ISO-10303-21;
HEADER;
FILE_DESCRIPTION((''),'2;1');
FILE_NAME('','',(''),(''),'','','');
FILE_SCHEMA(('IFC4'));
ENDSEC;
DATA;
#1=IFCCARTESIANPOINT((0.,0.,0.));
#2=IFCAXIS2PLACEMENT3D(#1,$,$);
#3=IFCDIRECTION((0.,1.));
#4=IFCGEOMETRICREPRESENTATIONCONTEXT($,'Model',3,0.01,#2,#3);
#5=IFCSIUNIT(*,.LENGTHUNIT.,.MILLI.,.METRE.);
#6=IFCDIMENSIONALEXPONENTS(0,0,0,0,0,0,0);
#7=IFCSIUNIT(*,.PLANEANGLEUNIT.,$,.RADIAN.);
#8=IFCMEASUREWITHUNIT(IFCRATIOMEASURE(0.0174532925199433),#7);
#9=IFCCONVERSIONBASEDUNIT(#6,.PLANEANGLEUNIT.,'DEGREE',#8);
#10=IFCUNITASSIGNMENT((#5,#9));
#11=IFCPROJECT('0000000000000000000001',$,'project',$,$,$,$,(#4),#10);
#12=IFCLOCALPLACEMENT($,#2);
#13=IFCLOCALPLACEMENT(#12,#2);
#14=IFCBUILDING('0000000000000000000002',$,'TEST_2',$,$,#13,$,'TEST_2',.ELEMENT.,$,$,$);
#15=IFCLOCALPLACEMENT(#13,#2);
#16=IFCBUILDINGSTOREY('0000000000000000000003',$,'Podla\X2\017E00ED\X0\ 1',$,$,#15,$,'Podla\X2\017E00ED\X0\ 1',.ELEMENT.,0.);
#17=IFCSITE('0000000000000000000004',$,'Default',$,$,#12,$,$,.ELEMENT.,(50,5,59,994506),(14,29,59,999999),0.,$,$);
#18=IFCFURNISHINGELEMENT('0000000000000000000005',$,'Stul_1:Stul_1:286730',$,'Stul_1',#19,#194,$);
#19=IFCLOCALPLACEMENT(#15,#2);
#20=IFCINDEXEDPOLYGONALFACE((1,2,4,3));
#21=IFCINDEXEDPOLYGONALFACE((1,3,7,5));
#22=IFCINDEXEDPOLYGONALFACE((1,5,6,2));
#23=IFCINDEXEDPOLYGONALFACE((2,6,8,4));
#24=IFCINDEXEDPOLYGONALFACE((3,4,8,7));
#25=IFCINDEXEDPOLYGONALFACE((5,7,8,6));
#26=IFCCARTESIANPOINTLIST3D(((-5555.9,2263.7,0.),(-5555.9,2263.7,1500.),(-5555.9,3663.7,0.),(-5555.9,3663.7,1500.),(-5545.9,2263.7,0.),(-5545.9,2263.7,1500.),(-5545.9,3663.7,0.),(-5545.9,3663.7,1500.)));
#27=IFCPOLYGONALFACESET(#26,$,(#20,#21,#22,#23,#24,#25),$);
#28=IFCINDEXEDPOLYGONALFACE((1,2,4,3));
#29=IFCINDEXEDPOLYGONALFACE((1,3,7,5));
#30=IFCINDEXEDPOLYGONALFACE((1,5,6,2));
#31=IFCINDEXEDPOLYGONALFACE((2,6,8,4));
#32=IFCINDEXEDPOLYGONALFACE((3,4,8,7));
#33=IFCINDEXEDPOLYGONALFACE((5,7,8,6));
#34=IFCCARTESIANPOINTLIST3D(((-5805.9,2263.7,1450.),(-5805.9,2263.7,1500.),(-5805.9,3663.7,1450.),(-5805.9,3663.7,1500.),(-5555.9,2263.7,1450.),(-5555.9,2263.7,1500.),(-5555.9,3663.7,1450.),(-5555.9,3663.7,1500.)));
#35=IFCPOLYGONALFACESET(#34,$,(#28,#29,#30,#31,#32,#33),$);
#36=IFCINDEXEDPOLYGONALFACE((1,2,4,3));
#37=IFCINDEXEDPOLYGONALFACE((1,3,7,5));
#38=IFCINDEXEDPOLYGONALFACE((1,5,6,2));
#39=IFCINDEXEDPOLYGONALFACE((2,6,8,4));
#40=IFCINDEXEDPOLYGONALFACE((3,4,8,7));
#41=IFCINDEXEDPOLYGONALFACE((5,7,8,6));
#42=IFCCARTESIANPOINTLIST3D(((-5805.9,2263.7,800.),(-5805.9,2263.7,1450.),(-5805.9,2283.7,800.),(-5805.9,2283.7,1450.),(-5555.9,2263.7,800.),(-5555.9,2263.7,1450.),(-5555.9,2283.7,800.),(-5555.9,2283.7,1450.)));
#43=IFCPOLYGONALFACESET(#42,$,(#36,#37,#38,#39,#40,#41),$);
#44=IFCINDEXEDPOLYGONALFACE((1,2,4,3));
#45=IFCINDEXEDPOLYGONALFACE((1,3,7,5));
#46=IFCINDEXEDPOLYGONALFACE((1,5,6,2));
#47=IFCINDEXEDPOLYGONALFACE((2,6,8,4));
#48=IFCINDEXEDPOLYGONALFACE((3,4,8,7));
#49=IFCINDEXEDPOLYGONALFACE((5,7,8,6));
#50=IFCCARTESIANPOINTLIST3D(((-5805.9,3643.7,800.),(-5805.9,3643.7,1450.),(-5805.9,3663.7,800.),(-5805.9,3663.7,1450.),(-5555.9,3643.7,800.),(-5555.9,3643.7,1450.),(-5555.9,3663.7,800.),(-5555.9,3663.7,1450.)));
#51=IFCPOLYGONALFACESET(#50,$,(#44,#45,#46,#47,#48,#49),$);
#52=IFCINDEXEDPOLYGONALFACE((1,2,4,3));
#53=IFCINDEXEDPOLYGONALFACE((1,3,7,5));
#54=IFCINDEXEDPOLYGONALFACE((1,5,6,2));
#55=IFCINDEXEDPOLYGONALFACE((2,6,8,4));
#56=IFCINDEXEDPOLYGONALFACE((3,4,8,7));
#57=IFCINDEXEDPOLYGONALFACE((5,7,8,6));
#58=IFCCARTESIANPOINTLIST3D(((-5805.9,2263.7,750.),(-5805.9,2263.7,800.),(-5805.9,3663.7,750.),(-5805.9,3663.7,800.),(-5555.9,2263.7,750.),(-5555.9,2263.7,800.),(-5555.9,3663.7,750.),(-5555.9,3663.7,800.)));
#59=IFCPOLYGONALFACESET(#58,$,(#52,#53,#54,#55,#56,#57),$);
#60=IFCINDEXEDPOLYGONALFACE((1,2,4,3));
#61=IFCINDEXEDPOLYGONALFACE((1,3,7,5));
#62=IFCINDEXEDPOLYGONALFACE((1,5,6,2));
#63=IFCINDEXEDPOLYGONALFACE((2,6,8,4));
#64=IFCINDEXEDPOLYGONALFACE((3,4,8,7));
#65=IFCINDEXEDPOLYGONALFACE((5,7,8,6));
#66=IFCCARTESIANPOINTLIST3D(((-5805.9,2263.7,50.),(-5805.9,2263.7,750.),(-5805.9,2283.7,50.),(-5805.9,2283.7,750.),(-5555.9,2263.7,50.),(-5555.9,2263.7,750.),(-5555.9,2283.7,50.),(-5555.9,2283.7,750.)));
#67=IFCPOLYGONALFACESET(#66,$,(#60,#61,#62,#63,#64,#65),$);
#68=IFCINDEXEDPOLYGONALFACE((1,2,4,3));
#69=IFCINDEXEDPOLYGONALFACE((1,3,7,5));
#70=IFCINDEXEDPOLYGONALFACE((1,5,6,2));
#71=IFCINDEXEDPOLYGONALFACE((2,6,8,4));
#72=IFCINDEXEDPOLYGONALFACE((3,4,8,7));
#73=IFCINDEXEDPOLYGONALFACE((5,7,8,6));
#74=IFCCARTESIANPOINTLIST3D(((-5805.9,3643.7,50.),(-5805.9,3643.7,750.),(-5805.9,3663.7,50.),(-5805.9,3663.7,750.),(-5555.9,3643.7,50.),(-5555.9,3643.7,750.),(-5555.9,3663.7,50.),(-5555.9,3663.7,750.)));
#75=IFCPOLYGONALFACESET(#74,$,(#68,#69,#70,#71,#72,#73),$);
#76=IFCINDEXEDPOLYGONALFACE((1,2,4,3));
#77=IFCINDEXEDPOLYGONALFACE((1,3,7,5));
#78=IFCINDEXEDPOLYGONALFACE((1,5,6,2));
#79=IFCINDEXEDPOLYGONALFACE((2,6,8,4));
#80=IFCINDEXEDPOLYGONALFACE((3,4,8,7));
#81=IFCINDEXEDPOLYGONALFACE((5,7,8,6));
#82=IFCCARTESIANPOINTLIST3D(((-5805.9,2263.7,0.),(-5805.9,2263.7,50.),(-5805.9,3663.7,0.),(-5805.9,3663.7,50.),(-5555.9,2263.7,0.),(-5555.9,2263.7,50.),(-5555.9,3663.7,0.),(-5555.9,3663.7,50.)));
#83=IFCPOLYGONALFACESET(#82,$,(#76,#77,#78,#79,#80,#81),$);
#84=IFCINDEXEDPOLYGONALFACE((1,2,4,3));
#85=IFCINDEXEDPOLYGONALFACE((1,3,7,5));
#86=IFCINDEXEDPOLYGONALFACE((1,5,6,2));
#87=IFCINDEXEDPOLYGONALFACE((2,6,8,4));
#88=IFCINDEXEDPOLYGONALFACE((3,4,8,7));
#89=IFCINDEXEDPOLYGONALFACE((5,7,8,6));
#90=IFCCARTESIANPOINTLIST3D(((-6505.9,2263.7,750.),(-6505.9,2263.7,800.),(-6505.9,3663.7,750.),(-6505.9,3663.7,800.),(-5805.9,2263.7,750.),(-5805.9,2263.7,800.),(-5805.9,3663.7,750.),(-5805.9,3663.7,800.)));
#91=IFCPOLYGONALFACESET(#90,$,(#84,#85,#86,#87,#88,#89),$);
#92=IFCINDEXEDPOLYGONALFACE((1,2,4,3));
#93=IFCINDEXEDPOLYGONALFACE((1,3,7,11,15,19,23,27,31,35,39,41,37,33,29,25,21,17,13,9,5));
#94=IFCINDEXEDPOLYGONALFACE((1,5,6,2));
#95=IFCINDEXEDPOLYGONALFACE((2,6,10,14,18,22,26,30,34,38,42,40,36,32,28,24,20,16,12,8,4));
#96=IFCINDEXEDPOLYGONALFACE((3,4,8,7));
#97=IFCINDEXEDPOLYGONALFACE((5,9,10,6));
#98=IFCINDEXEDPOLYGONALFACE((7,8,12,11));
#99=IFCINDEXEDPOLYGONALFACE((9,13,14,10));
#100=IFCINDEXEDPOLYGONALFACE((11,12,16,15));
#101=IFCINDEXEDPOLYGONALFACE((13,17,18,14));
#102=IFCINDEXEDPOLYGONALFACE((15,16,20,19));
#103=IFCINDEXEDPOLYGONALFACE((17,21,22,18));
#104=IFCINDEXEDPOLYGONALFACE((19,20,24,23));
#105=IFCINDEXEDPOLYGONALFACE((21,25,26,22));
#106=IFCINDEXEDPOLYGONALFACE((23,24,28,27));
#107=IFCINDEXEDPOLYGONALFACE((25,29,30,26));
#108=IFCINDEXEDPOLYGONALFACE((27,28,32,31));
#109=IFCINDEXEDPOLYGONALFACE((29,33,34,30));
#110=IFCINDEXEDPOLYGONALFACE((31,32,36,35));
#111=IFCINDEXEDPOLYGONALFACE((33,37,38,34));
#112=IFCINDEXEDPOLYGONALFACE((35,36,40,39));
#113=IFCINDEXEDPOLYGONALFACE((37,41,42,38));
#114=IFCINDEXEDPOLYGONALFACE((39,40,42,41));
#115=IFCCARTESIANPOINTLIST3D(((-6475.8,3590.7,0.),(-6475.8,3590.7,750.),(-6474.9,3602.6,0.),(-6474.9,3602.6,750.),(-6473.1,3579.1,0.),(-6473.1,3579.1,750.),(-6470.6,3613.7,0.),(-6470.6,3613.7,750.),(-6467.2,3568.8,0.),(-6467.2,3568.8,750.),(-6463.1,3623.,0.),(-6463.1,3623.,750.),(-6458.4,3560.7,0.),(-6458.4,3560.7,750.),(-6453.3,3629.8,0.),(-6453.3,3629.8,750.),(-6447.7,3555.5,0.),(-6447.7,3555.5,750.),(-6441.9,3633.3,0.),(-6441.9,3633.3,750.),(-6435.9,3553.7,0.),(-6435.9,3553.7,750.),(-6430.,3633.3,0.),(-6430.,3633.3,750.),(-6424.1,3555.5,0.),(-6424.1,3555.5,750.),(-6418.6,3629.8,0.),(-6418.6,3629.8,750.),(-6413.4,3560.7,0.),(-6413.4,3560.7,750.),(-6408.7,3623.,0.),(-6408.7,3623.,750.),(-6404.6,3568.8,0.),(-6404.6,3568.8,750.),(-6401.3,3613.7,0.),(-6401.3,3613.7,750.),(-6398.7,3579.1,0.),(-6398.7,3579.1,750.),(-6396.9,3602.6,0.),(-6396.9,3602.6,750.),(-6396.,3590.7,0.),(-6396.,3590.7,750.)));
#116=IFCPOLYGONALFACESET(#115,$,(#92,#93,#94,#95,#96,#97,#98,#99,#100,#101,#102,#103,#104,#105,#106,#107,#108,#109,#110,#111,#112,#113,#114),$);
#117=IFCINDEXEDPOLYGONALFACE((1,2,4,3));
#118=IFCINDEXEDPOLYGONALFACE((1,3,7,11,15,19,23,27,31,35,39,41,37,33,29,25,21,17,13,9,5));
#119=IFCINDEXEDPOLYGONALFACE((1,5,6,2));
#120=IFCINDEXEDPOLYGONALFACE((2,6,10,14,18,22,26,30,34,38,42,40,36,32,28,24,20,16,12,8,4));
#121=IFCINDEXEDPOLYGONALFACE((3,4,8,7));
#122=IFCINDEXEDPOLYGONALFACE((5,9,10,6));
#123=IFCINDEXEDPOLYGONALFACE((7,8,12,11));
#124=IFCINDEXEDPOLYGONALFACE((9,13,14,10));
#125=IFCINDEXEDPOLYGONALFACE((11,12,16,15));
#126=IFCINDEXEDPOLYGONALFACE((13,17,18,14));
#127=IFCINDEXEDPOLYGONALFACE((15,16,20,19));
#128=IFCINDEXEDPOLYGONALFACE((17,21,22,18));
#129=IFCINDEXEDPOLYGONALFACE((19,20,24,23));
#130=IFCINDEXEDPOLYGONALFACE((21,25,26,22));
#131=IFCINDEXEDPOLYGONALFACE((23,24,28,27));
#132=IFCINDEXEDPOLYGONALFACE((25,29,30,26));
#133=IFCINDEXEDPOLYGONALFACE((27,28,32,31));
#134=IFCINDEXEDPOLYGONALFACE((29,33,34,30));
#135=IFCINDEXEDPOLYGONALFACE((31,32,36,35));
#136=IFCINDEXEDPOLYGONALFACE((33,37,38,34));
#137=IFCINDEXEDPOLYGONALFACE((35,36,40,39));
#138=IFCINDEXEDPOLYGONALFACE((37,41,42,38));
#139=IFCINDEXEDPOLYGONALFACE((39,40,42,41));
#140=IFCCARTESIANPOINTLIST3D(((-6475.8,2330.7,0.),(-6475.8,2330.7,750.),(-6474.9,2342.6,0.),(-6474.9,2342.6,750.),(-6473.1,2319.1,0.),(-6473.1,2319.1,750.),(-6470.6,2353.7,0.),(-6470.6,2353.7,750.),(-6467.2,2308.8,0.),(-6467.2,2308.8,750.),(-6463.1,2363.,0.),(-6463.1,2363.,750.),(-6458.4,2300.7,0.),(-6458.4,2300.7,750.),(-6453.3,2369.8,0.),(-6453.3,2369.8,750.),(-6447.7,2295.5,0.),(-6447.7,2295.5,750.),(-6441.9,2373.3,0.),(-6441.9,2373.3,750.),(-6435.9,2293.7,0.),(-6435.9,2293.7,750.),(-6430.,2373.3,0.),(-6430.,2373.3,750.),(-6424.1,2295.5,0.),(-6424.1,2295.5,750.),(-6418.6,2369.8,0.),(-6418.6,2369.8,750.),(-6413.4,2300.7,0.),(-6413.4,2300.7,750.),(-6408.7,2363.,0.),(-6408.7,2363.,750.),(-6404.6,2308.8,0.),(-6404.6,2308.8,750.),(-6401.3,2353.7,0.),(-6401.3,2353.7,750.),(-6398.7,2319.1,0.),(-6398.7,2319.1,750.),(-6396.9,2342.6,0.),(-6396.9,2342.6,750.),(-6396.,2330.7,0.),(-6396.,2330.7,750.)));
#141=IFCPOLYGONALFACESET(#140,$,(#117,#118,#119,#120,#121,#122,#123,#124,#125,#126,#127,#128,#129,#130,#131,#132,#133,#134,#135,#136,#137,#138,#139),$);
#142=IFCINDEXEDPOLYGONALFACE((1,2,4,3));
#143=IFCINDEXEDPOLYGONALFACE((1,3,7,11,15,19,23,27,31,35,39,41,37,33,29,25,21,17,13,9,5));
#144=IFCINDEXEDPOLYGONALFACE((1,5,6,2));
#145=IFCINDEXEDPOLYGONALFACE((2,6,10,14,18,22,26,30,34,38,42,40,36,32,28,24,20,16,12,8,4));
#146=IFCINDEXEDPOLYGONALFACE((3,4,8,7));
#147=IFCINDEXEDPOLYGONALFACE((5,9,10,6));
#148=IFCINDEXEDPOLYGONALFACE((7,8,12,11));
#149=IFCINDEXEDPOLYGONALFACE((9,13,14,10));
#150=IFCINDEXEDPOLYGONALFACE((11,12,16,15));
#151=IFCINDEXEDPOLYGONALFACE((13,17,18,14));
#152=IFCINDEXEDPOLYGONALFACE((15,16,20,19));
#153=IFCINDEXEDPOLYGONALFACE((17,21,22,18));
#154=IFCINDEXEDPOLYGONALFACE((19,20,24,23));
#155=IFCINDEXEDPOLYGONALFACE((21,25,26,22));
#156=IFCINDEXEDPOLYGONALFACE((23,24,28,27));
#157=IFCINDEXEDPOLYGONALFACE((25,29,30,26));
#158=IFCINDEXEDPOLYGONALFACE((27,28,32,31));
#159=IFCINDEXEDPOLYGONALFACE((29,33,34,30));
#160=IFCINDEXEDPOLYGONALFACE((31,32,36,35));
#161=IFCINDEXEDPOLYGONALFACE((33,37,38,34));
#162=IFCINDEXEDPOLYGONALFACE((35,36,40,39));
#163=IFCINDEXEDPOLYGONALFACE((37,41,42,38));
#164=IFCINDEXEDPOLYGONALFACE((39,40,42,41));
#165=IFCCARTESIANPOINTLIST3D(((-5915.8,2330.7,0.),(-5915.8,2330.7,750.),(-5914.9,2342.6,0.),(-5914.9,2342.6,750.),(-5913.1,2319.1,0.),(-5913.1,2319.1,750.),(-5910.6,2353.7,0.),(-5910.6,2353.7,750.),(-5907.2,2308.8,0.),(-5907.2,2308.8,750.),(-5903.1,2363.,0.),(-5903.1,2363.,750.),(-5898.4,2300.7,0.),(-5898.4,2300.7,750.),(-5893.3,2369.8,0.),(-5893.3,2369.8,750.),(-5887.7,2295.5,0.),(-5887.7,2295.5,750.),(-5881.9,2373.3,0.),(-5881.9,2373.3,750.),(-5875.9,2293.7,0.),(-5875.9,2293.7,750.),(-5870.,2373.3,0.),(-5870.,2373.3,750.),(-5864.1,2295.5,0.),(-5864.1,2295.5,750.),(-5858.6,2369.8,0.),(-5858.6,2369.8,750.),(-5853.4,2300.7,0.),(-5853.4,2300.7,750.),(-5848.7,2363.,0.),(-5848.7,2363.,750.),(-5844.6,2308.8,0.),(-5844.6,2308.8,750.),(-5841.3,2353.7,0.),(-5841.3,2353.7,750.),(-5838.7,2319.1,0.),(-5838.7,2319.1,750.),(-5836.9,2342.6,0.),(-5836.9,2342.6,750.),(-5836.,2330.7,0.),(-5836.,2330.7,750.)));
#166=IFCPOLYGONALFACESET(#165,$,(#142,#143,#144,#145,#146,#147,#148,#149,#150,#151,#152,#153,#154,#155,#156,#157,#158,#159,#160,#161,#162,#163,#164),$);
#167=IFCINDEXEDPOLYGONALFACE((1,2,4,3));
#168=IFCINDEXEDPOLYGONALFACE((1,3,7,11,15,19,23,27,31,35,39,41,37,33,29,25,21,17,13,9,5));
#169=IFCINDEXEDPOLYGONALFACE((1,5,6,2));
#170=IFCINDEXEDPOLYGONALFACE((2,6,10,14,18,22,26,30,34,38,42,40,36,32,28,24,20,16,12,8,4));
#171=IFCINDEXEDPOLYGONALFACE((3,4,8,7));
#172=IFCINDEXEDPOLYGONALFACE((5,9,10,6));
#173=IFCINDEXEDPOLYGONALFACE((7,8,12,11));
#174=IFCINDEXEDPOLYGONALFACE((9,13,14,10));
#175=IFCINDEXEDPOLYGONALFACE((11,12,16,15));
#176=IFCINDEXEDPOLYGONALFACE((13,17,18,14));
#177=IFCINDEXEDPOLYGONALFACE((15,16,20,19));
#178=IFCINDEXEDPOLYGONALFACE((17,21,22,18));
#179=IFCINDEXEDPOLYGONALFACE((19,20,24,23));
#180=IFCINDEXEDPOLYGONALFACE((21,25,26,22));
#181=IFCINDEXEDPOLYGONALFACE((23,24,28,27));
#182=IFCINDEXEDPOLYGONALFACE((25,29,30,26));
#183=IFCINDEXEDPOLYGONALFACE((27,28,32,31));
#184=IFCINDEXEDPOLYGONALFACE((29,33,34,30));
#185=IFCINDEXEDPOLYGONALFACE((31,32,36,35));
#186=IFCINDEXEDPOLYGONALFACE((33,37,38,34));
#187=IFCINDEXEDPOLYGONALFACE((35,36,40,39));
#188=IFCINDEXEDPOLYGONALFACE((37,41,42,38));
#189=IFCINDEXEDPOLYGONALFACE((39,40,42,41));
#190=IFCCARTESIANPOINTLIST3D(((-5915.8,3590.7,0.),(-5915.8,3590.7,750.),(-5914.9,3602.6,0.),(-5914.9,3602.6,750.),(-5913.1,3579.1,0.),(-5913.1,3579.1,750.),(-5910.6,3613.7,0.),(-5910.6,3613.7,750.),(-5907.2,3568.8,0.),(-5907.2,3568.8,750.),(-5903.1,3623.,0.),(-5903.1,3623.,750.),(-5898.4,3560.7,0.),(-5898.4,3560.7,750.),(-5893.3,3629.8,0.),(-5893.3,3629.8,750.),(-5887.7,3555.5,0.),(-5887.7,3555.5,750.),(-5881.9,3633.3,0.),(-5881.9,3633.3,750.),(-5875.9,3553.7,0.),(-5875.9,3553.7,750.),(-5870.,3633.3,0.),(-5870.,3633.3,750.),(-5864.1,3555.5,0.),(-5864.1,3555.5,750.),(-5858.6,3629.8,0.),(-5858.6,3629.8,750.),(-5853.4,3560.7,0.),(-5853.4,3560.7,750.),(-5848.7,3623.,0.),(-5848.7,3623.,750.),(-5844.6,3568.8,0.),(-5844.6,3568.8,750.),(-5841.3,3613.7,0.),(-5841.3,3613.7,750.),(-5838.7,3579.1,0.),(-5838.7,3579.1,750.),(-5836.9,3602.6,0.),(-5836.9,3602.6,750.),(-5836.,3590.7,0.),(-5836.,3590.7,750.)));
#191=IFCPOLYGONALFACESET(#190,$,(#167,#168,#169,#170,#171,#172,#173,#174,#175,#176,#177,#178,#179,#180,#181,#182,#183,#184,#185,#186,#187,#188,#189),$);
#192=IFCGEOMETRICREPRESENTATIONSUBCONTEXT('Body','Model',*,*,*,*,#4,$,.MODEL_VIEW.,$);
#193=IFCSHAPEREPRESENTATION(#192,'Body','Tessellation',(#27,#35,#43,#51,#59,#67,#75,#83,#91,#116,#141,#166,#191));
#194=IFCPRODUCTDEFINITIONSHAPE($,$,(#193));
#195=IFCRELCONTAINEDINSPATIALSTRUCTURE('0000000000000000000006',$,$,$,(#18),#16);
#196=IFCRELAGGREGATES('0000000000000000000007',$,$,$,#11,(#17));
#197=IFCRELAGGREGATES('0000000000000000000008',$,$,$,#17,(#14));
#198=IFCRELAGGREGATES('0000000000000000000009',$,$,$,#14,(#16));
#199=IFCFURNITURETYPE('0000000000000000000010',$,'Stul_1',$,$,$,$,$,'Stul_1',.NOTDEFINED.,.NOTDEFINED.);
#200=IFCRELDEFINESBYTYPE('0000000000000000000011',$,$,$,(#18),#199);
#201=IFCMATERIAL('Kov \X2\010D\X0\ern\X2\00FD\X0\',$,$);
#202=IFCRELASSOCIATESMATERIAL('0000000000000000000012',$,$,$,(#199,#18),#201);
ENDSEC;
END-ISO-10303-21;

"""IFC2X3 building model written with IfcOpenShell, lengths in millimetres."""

from ifc_helpers import new_model, entity, si_unit, converted_unit, direction, frame, frame_2d, origin, origin_2d_with_axis, place, context, subcontext, project, spatial, rectangle, circle, extrude, source, transform, mapped, material, type_object, type_shapes, element, save


model = new_model("IFC2X3")

# Units and contexts
model_context = context("Model", 3, precision=0.01, world=origin(), true_north=direction((0.0, 1.0)))
body_context = subcontext(model_context, "Body", "Model", "MODEL_VIEW")
ifc_project = project(units=[si_unit("LENGTHUNIT", "METRE", prefix="MILLI"), converted_unit("PLANEANGLEUNIT", "DEGREE", entity("IfcRatioMeasure", 0.0174532925199433), si_unit("PLANEANGLEUNIT", "RADIAN"), dimensions=[0, 0, 0, 0, 0, 0, 0])], contexts=[model_context])

# Site, building, storey
site_placement = place(None, origin())
site = spatial("IfcSite", under=ifc_project, at=site_placement, Name="Default", CompositionType="ELEMENT", RefLatitude=(50, 5, 59, 994506), RefLongitude=(14, 29, 59, 999999), RefElevation=0.0)
building_placement = place(site_placement, origin())
building = spatial("IfcBuilding", under=site, at=building_placement, Name="TEST_2", LongName="TEST_2", CompositionType="ELEMENT")
storey_placement = place(building_placement, origin())
storey = spatial("IfcBuildingStorey", under=building, at=storey_placement, Name="Podlaží 1", LongName="Podlaží 1", CompositionType="ELEMENT", Elevation=0.0)

# Furnishing element
ifc_material_1 = material(Name="Kov černý")
furniture_type = type_object("IfcFurnitureType", Name="Stul_1", ElementType="Stul_1", material=ifc_material_1)
shared_shape_1 = source(origin(), body_context, "Body", "SweptSolid", [
    extrude(rectangle(XDim=1400.0, YDim=10.0, at=origin_2d_with_axis()), frame((0.0, 605.0, 0.0), z_axis=(0.0, 0.0, 1.0), x_axis=(-1.0, 0.0, 0.0)), (0.0, 0.0, 1.0), 1500.0),
    extrude(rectangle(XDim=1400.0, YDim=250.0, at=frame_2d((0.0, 0.0), x_axis=(1.0, 0.0))), frame((0.0, 475.0, 1450.0), z_axis=(0.0, 0.0, 1.0), x_axis=(-1.0, 0.0, 0.0)), (0.0, 0.0, 1.0), 50.0),
    extrude(rectangle(XDim=20.0, YDim=250.0, at=origin_2d_with_axis()), frame((690.0, 475.0, 800.0), z_axis=(0.0, 0.0, 1.0), x_axis=(-1.0, 0.0, 0.0)), (0.0, 0.0, 1.0), 650.0),
    extrude(rectangle(XDim=20.0, YDim=250.0, at=frame_2d((0.0, 0.0), x_axis=(1.0, 0.0))), frame((-690.0, 475.0, 800.0), z_axis=(0.0, 0.0, 1.0), x_axis=(-1.0, 0.0, 0.0)), (0.0, 0.0, 1.0), 650.0),
    extrude(rectangle(XDim=1400.0, YDim=250.0, at=origin_2d_with_axis()), frame((0.0, 475.0, 750.0), z_axis=(0.0, 0.0, 1.0), x_axis=(-1.0, 0.0, 0.0)), (0.0, 0.0, 1.0), 50.0),
    extrude(rectangle(XDim=20.0, YDim=250.0, at=origin_2d_with_axis()), frame((690.0, 475.0, 50.0), z_axis=(0.0, 0.0, 1.0), x_axis=(-1.0, 0.0, 0.0)), (0.0, 0.0, 1.0), 700.0),
    extrude(rectangle(XDim=20.0, YDim=250.0, at=frame_2d((0.0, 0.0), x_axis=(1.0, 0.0))), frame((-690.0, 475.0, 50.0), z_axis=(0.0, 0.0, 1.0), x_axis=(-1.0, 0.0, 0.0)), (0.0, 0.0, 1.0), 700.0),
    extrude(rectangle(XDim=1400.0, YDim=250.0, at=origin_2d_with_axis()), frame((0.0, 475.0, 0.0), z_axis=(0.0, 0.0, 1.0), x_axis=(-1.0, 0.0, 0.0)), (0.0, 0.0, 1.0), 50.0),
    extrude(rectangle(XDim=1400.0, YDim=700.0, at=origin_2d_with_axis()), frame((0.0, 0.0, 750.0), z_axis=(0.0, 0.0, 1.0), x_axis=(-1.0, 0.0, 0.0)), (0.0, 0.0, 1.0), 50.0),
    extrude(circle(Radius=40.0, at=frame_2d((0.0, 0.0), x_axis=(1.0, 0.0))), frame((-630.0, -280.0, 0.0)), (0.0, 0.0, 1.0), 750.0),
    extrude(circle(Radius=40.0, at=frame_2d((0.0, 0.0), x_axis=(1.0, 0.0))), frame((630.0, -280.0, 0.0)), (0.0, 0.0, 1.0), 750.0),
    extrude(circle(Radius=40.0, at=frame_2d((0.0, 0.0), x_axis=(1.0, 0.0))), frame((630.0, 280.0, 0.0)), (0.0, 0.0, 1.0), 750.0),
    extrude(circle(Radius=40.0, at=frame_2d((0.0, 0.0), x_axis=(1.0, 0.0))), frame((-630.0, 280.0, 0.0)), (0.0, 0.0, 1.0), 750.0),
])
type_shapes(furniture_type, [shared_shape_1])
for number, where, z_axis, x_axis, name in (
    (1, (-6155.9, 2963.7, 0.0), (0.0, 0.0, 1.0), (0.0, -1.0, 0.0), "Stul_1:Stul_1:286730"),
):
    element("IfcFurnishingElement", number, at=place(storey_placement, frame(where, z_axis=z_axis, x_axis=x_axis)), inside=storey, type_object=furniture_type, material=ifc_material_1, Name=name, ObjectType="Stul_1", context=body_context, shape_type="MappedRepresentation", body=[
        mapped(shared_shape_1, transform((0.0, 0.0, 0.0), scale=1.0)),
    ])

save(model, "model.ifc")
